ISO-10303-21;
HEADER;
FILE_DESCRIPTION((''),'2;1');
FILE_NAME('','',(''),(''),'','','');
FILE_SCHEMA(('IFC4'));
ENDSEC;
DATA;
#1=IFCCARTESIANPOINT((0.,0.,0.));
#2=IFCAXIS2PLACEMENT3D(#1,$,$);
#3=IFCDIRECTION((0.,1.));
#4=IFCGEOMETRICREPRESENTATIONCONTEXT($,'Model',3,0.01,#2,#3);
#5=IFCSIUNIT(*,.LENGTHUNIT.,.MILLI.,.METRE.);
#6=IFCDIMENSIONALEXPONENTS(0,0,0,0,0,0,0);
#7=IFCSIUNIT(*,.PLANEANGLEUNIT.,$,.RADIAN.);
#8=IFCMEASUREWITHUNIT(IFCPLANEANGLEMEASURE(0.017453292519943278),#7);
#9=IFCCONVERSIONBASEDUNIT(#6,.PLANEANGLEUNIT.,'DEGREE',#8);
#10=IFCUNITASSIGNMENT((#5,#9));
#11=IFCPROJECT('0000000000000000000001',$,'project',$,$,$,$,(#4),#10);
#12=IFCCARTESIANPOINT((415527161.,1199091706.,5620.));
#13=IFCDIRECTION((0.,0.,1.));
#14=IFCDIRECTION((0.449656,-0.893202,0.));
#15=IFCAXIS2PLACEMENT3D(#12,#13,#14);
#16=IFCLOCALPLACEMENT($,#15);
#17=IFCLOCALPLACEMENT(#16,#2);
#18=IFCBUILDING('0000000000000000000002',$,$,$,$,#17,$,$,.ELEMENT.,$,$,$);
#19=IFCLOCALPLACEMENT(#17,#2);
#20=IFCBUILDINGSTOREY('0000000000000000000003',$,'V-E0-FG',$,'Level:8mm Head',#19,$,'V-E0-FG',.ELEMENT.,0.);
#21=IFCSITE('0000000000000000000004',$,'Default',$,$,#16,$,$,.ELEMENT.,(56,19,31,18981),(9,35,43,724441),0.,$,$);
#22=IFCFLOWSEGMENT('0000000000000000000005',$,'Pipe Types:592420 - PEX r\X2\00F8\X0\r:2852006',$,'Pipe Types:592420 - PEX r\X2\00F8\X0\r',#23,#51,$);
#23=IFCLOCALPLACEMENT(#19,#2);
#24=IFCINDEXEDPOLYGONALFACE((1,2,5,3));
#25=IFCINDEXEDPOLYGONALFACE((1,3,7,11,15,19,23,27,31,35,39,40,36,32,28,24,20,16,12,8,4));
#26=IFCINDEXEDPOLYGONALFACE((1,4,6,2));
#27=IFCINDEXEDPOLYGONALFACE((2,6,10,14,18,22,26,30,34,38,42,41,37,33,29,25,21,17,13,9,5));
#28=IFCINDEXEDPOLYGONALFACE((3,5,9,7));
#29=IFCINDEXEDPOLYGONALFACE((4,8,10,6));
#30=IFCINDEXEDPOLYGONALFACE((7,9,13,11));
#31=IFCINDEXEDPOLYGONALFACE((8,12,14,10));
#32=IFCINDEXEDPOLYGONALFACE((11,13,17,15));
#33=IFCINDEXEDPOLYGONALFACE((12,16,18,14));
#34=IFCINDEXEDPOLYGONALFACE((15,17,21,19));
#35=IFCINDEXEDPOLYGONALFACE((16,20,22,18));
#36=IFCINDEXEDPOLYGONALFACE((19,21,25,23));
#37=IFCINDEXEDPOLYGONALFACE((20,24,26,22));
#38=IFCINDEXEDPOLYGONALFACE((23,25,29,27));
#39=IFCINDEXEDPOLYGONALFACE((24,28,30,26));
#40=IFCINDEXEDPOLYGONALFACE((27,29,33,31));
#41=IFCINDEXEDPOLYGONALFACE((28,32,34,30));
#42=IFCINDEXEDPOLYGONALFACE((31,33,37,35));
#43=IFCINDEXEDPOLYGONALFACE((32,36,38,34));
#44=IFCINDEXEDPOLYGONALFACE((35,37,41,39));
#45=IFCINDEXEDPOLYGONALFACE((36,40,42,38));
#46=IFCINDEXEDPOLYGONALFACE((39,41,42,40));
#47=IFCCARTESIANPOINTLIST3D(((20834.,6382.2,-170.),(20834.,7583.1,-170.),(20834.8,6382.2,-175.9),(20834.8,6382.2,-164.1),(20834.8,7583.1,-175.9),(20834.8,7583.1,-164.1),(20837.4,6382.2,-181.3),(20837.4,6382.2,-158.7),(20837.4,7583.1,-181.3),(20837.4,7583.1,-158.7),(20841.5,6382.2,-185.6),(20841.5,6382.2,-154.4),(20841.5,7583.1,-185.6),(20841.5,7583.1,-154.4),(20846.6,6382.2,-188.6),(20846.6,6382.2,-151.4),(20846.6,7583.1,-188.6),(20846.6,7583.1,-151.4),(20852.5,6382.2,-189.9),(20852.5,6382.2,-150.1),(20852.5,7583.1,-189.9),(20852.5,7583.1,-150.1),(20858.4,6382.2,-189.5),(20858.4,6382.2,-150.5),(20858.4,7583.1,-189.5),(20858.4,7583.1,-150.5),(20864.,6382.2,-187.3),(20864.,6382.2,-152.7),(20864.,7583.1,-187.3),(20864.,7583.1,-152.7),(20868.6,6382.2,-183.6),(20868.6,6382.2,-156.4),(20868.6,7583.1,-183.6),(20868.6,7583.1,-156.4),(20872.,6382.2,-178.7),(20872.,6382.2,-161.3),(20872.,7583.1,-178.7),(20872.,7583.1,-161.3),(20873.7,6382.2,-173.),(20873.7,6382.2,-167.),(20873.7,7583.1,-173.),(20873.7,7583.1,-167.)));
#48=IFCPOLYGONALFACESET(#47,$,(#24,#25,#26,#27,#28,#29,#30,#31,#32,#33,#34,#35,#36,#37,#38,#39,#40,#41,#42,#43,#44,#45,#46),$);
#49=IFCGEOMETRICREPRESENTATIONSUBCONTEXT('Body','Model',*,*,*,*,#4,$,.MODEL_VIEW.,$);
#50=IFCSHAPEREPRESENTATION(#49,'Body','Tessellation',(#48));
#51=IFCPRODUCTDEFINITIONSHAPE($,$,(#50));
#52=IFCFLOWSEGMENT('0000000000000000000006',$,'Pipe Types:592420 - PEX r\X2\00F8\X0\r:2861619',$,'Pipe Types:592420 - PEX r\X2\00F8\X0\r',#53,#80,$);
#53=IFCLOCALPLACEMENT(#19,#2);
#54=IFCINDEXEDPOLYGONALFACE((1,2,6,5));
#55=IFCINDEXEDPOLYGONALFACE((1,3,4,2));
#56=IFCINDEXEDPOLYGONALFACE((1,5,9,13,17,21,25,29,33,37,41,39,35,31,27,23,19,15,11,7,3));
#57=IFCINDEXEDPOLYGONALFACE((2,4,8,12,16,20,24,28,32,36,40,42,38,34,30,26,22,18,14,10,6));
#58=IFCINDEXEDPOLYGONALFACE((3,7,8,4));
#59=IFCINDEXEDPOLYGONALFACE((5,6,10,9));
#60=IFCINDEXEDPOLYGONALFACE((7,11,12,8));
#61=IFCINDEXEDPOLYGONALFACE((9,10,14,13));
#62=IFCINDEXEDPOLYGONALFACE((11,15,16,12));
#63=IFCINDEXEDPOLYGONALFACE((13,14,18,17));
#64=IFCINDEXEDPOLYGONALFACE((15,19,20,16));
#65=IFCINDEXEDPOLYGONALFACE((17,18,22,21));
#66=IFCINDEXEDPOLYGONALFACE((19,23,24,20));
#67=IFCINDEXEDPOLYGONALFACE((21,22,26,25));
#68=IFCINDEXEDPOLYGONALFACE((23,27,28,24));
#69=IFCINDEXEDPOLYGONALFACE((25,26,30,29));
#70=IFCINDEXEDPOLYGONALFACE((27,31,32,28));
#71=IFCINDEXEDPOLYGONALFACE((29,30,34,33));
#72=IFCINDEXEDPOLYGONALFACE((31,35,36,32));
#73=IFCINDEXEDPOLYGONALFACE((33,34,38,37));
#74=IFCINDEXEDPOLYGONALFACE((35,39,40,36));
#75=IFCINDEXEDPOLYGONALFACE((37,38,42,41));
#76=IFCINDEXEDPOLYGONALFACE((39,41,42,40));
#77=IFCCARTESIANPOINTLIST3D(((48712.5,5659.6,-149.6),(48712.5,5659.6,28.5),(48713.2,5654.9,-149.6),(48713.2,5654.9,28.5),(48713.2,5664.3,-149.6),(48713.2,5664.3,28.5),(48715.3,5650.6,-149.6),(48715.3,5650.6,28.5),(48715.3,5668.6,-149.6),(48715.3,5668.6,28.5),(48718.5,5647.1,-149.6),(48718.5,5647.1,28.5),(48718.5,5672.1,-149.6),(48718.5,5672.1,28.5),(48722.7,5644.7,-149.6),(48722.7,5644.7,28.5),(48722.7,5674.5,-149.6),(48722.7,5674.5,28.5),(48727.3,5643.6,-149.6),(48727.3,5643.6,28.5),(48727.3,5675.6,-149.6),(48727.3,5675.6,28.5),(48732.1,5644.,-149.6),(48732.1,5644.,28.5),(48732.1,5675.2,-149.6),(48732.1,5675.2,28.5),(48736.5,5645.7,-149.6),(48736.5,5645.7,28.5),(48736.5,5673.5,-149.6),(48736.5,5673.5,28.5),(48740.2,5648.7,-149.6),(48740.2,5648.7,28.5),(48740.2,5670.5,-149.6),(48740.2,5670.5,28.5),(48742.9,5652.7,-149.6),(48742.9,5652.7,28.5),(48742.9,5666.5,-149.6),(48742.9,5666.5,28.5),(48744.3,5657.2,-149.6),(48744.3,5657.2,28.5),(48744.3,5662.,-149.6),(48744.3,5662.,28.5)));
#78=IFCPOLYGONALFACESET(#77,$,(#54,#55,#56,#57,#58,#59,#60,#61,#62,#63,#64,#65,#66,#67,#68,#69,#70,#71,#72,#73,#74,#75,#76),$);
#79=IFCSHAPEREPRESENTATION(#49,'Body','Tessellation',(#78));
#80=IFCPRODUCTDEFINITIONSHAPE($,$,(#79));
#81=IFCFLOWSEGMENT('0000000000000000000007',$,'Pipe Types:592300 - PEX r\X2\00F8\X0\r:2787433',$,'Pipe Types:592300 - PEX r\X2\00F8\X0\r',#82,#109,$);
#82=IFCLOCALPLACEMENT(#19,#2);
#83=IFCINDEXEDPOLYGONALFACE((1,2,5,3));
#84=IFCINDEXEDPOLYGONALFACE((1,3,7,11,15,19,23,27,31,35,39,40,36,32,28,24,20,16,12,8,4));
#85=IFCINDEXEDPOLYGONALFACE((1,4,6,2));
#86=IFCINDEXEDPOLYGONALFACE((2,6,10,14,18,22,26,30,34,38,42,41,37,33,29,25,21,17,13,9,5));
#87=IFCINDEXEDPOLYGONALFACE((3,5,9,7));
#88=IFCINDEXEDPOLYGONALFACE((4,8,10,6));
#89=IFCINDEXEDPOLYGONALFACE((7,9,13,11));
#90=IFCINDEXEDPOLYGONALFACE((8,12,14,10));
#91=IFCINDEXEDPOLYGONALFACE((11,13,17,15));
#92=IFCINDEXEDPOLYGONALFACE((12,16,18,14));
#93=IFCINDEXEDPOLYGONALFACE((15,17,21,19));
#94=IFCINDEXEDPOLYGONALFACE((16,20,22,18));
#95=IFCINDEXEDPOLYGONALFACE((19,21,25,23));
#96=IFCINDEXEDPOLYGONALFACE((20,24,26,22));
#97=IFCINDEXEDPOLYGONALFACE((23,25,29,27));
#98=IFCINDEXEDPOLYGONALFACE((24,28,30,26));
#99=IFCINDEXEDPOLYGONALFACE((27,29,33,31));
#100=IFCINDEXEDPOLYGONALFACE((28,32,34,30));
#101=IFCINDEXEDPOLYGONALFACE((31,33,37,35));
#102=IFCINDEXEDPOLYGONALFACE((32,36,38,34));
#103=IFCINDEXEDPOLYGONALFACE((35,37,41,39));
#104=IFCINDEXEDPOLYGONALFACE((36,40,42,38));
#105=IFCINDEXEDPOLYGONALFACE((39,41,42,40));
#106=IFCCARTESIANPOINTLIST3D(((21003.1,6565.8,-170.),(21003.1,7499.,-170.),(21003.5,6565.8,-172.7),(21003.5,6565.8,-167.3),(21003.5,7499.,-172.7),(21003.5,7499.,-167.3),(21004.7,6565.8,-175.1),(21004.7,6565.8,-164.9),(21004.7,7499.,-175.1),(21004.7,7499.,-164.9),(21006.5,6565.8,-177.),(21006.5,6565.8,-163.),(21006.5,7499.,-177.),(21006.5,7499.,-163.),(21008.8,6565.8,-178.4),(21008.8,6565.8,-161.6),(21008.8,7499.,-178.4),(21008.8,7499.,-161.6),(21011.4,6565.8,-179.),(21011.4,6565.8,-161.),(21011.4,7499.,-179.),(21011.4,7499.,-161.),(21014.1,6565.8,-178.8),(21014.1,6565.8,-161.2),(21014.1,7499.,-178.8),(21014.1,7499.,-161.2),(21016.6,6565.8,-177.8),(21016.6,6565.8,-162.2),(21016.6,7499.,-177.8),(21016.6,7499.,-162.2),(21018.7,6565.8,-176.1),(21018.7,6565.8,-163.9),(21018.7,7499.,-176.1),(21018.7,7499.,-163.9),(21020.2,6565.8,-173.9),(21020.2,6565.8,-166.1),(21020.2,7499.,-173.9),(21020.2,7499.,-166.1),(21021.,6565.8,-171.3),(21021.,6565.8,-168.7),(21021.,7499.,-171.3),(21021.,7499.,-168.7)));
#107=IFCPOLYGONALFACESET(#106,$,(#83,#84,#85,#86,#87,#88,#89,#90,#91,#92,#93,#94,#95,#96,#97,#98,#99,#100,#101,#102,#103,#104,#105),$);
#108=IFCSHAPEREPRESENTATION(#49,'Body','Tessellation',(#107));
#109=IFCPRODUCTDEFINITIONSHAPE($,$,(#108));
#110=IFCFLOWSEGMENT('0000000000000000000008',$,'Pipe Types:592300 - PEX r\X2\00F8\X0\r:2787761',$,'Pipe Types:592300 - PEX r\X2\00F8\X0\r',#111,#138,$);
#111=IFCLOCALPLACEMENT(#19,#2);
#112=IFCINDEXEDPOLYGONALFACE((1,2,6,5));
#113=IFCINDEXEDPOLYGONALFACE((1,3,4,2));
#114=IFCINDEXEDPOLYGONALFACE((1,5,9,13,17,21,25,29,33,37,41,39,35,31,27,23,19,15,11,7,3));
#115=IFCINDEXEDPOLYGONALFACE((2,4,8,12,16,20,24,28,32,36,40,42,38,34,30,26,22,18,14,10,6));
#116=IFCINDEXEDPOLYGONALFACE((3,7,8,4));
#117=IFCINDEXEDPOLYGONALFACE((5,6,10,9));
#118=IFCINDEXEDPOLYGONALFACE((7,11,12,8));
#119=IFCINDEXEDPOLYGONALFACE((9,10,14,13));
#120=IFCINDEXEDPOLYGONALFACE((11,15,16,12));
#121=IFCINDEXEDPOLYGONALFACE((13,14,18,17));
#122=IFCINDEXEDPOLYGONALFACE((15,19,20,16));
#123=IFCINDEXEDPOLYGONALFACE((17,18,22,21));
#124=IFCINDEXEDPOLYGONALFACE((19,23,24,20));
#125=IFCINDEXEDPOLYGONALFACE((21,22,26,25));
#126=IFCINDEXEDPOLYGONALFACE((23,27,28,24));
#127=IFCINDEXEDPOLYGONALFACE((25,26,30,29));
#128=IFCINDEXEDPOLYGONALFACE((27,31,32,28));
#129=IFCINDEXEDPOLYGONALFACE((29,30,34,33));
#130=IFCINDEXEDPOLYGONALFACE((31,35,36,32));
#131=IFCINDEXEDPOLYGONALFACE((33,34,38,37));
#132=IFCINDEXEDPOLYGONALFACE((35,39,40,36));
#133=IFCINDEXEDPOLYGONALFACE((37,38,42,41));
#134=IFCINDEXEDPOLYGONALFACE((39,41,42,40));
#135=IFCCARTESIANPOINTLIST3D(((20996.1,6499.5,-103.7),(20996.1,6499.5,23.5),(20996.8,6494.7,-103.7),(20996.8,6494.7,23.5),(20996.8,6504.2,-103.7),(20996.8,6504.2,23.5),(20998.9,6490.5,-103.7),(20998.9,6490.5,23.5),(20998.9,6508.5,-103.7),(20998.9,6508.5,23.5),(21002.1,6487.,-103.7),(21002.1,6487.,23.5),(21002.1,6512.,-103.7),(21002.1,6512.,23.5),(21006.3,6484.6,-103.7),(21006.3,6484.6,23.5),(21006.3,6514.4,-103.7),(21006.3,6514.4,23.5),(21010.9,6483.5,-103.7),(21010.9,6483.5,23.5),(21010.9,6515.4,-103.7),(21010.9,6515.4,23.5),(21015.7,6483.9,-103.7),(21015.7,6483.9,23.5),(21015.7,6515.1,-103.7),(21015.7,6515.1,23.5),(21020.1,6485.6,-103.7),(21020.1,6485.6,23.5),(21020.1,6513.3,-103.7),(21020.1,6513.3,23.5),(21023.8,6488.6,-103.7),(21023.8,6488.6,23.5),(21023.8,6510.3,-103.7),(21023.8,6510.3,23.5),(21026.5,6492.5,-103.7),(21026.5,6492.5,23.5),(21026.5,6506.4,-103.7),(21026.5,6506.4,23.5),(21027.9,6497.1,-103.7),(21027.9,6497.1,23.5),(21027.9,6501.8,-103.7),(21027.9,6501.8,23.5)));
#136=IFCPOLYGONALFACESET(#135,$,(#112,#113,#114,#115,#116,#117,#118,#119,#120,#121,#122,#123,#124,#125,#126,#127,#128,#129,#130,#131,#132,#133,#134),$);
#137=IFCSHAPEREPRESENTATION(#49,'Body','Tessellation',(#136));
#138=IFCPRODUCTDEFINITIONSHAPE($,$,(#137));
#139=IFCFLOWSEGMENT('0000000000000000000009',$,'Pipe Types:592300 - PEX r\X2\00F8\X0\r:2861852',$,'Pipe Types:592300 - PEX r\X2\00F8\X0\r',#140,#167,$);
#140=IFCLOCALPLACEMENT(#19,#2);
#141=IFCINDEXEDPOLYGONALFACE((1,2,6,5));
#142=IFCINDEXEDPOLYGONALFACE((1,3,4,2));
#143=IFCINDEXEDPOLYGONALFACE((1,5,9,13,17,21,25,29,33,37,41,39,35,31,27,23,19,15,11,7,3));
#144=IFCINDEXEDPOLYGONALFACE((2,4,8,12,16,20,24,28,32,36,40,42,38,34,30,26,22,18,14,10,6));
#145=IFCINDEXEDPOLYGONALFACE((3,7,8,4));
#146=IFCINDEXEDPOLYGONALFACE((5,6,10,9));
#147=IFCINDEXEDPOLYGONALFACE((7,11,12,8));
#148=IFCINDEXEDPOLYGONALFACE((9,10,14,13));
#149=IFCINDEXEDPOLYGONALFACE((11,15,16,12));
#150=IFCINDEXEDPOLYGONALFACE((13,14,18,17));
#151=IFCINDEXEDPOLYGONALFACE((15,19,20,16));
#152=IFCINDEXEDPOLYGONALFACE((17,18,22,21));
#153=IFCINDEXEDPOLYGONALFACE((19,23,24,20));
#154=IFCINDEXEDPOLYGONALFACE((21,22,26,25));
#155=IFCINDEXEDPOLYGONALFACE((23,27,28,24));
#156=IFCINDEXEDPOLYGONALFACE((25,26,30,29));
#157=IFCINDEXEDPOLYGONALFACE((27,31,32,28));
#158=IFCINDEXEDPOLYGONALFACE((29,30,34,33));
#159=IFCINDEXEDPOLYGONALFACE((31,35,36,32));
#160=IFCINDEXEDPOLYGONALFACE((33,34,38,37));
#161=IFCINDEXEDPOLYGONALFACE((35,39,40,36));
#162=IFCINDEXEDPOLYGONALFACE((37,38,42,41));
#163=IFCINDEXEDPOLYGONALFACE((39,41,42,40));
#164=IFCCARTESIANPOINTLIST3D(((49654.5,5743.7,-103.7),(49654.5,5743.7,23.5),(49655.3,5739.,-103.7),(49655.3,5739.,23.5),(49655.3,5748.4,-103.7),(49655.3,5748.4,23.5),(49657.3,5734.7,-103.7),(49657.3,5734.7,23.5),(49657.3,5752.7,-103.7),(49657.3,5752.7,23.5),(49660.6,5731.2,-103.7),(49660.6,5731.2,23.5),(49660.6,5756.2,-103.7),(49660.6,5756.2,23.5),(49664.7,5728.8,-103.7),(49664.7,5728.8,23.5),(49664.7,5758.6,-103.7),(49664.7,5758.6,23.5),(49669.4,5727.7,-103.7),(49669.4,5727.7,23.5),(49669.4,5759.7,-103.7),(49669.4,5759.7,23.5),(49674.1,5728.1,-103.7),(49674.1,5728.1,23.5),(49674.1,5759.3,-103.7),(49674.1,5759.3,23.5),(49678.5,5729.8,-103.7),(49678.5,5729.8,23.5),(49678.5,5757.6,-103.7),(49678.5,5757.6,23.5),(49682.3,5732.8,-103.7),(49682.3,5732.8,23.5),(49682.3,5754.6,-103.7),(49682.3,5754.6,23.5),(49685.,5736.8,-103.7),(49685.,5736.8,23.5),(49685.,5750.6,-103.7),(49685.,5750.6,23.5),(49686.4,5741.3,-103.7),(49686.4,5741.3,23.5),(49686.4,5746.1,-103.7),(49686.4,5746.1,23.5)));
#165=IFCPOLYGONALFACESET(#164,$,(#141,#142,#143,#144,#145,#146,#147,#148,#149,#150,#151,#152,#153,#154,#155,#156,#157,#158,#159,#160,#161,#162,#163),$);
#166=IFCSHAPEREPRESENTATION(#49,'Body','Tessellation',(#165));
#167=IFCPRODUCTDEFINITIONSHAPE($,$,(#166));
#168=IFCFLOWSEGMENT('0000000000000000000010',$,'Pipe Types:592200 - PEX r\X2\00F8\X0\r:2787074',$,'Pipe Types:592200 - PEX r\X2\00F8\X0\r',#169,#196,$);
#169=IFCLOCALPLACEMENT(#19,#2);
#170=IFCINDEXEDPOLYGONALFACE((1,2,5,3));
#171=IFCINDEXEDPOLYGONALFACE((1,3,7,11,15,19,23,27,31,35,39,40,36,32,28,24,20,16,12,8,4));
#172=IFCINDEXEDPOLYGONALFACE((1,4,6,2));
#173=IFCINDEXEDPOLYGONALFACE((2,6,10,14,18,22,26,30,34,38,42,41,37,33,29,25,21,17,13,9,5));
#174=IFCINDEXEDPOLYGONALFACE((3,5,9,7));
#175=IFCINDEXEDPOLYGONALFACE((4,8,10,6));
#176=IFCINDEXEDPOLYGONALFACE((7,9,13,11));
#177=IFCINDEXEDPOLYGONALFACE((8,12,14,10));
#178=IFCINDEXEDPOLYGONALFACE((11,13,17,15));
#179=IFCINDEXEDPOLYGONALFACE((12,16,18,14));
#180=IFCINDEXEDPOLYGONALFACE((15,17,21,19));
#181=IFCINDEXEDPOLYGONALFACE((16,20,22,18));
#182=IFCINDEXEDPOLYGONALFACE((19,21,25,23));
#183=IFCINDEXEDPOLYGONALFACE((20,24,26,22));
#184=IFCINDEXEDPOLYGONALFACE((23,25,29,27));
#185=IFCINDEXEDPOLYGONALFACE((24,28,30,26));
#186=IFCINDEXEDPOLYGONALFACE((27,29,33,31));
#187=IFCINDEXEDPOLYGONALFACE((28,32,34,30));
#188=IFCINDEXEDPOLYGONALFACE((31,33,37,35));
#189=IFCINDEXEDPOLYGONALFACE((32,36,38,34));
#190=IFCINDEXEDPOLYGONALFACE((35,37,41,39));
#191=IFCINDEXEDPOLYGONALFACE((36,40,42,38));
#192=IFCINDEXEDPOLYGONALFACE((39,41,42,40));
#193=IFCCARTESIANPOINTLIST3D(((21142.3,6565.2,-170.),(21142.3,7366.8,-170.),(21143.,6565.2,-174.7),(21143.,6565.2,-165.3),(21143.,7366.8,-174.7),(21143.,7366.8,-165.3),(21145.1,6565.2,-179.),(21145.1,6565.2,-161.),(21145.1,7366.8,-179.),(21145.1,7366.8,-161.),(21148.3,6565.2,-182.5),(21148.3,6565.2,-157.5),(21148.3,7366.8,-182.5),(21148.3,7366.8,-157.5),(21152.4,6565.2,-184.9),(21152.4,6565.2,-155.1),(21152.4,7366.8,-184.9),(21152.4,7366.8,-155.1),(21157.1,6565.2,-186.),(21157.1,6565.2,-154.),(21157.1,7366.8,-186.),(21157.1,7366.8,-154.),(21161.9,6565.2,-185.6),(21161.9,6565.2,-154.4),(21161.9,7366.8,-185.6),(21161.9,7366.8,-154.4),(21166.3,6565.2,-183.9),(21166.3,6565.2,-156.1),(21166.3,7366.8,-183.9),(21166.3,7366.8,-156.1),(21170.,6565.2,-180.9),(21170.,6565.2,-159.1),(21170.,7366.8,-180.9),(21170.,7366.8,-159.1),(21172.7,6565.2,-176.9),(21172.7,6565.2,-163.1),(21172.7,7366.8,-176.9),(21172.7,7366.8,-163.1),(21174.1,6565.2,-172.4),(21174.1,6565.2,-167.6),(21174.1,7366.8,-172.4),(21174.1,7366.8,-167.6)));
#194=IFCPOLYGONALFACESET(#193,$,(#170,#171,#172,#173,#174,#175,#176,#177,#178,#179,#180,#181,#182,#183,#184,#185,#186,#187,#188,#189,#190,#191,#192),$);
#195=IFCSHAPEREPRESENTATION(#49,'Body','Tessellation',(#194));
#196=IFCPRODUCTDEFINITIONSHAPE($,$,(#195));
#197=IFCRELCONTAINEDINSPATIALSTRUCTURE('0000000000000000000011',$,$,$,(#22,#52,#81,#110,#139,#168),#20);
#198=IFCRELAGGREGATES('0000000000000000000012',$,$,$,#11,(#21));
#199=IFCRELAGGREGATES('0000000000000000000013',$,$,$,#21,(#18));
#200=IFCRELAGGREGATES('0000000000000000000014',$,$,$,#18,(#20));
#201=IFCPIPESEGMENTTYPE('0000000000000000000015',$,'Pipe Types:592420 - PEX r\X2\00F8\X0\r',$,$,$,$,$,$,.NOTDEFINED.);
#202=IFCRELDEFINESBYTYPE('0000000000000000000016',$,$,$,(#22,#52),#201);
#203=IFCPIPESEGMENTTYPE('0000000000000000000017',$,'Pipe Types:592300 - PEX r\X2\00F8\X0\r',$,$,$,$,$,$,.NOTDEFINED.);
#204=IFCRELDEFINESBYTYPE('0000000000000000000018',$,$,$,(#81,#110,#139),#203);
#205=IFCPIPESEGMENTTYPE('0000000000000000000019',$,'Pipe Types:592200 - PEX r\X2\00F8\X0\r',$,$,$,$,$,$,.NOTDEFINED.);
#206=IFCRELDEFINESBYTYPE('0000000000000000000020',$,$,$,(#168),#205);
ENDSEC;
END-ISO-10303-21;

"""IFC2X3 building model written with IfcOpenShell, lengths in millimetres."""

from ifc_helpers import new_model, entity, si_unit, converted_unit, direction, frame, frame_2d, origin, origin_2d_with_axis, place, context, subcontext, project, spatial, circle, extrude, type_object, element, save


model = new_model("IFC2X3")

# Units and contexts
model_context = context("Model", 3, precision=0.01, world=origin(), true_north=direction((0.0, 1.0)))
body_context = subcontext(model_context, "Body", "Model", "MODEL_VIEW")
ifc_project = project(units=[si_unit("LENGTHUNIT", "METRE", prefix="MILLI"), converted_unit("PLANEANGLEUNIT", "DEGREE", entity("IfcPlaneAngleMeasure", 0.017453292519943278), si_unit("PLANEANGLEUNIT", "RADIAN"), dimensions=[0, 0, 0, 0, 0, 0, 0])], contexts=[model_context])

# Site, building, storey
site_placement = place(None, frame((415527161.0, 1199091706.0, 5620.0), z_axis=(0.0, 0.0, 1.0), x_axis=(0.449656, -0.893202, 0.0)))
site = spatial("IfcSite", under=ifc_project, at=site_placement, Name="Default", CompositionType="ELEMENT", RefLatitude=(56, 19, 31, 18981), RefLongitude=(9, 35, 43, 724441), RefElevation=0.0)
building_placement = place(site_placement, origin())
building = spatial("IfcBuilding", under=site, at=building_placement, CompositionType="ELEMENT")
storey_placement = place(building_placement, origin())
storey = spatial("IfcBuildingStorey", under=building, at=storey_placement, Name="V-E0-FG", ObjectType="Level:8mm Head", LongName="V-E0-FG", CompositionType="ELEMENT", Elevation=0.0)

# Flow segments
pipe_segment_type_1 = type_object("IfcPipeSegmentType", Name="Pipe Types:592420 - PEX rør", PredefinedType="NOTDEFINED")
flow_segment_1_placement = place(storey_placement, origin())
element("IfcFlowSegment", 1, at=flow_segment_1_placement, inside=storey, type_object=pipe_segment_type_1, Name="Pipe Types:592420 - PEX rør:2852006", ObjectType="Pipe Types:592420 - PEX rør", context=body_context, shape_type="SweptSolid", body=[
    extrude(circle(Radius=20.0, at=frame_2d((0.0, 0.0), x_axis=(1.0, 0.0))), frame((20854.0, 6382.2, -170.0), z_axis=(0.0, 1.0, 0.0), x_axis=(-1.0, 0.0, 0.0)), (0.0, 0.0, 1.0), 1200.9),
])
flow_segment_2_placement = place(storey_placement, origin())
element("IfcFlowSegment", 2, at=flow_segment_2_placement, inside=storey, type_object=pipe_segment_type_1, Name="Pipe Types:592420 - PEX rør:2861619", ObjectType="Pipe Types:592420 - PEX rør", context=body_context, shape_type="SweptSolid", body=[
    extrude(circle(Radius=16.0, at=origin_2d_with_axis()), frame((48728.5, 5659.6, -149.6), z_axis=(0.0, 0.0, 1.0), x_axis=(-1.0, 0.0, 0.0)), (0.0, 0.0, 1.0), 178.1),
])
pipe_segment_type_2 = type_object("IfcPipeSegmentType", Name="Pipe Types:592300 - PEX rør", PredefinedType="NOTDEFINED")
flow_segment_3_placement = place(storey_placement, origin())
element("IfcFlowSegment", 3, at=flow_segment_3_placement, inside=storey, type_object=pipe_segment_type_2, Name="Pipe Types:592300 - PEX rør:2787433", ObjectType="Pipe Types:592300 - PEX rør", context=body_context, shape_type="SweptSolid", body=[
    extrude(circle(Radius=9.0, at=origin_2d_with_axis()), frame((21012.1, 6565.8, -170.0), z_axis=(0.0, 1.0, 0.0), x_axis=(-1.0, 0.0, 0.0)), (0.0, 0.0, 1.0), 933.2),
])
flow_segment_4_placement = place(storey_placement, origin())
element("IfcFlowSegment", 4, at=flow_segment_4_placement, inside=storey, type_object=pipe_segment_type_2, Name="Pipe Types:592300 - PEX rør:2787761", ObjectType="Pipe Types:592300 - PEX rør", context=body_context, shape_type="SweptSolid", body=[
    extrude(circle(Radius=16.0, at=origin_2d_with_axis()), frame((21012.1, 6499.5, -103.7), z_axis=(0.0, 0.0, 1.0), x_axis=(-1.0, 0.0, 0.0)), (0.0, 0.0, 1.0), 127.2),
])
flow_segment_5_placement = place(storey_placement, origin())
element("IfcFlowSegment", 5, at=flow_segment_5_placement, inside=storey, type_object=pipe_segment_type_2, Name="Pipe Types:592300 - PEX rør:2861852", ObjectType="Pipe Types:592300 - PEX rør", context=body_context, shape_type="SweptSolid", body=[
    extrude(circle(Radius=16.0, at=frame_2d((0.0, 0.0), x_axis=(1.0, 0.0))), frame((49670.5, 5743.7, -103.7), z_axis=(0.0, 0.0, 1.0), x_axis=(-1.0, 0.0, 0.0)), (0.0, 0.0, 1.0), 127.2),
])
pipe_segment_type_3 = type_object("IfcPipeSegmentType", Name="Pipe Types:592200 - PEX rør", PredefinedType="NOTDEFINED")
flow_segment_6_placement = place(storey_placement, origin())
element("IfcFlowSegment", 6, at=flow_segment_6_placement, inside=storey, type_object=pipe_segment_type_3, Name="Pipe Types:592200 - PEX rør:2787074", ObjectType="Pipe Types:592200 - PEX rør", context=body_context, shape_type="SweptSolid", body=[
    extrude(circle(Radius=16.0, at=frame_2d((0.0, 0.0), x_axis=(1.0, 0.0))), frame((21158.3, 6565.2, -170.0), z_axis=(-0.000001, 1.0, 0.0), x_axis=(-1.0, -0.000001, 0.0)), (0.0, 0.0, 1.0), 801.6),
])

save(model, "model.ifc")
